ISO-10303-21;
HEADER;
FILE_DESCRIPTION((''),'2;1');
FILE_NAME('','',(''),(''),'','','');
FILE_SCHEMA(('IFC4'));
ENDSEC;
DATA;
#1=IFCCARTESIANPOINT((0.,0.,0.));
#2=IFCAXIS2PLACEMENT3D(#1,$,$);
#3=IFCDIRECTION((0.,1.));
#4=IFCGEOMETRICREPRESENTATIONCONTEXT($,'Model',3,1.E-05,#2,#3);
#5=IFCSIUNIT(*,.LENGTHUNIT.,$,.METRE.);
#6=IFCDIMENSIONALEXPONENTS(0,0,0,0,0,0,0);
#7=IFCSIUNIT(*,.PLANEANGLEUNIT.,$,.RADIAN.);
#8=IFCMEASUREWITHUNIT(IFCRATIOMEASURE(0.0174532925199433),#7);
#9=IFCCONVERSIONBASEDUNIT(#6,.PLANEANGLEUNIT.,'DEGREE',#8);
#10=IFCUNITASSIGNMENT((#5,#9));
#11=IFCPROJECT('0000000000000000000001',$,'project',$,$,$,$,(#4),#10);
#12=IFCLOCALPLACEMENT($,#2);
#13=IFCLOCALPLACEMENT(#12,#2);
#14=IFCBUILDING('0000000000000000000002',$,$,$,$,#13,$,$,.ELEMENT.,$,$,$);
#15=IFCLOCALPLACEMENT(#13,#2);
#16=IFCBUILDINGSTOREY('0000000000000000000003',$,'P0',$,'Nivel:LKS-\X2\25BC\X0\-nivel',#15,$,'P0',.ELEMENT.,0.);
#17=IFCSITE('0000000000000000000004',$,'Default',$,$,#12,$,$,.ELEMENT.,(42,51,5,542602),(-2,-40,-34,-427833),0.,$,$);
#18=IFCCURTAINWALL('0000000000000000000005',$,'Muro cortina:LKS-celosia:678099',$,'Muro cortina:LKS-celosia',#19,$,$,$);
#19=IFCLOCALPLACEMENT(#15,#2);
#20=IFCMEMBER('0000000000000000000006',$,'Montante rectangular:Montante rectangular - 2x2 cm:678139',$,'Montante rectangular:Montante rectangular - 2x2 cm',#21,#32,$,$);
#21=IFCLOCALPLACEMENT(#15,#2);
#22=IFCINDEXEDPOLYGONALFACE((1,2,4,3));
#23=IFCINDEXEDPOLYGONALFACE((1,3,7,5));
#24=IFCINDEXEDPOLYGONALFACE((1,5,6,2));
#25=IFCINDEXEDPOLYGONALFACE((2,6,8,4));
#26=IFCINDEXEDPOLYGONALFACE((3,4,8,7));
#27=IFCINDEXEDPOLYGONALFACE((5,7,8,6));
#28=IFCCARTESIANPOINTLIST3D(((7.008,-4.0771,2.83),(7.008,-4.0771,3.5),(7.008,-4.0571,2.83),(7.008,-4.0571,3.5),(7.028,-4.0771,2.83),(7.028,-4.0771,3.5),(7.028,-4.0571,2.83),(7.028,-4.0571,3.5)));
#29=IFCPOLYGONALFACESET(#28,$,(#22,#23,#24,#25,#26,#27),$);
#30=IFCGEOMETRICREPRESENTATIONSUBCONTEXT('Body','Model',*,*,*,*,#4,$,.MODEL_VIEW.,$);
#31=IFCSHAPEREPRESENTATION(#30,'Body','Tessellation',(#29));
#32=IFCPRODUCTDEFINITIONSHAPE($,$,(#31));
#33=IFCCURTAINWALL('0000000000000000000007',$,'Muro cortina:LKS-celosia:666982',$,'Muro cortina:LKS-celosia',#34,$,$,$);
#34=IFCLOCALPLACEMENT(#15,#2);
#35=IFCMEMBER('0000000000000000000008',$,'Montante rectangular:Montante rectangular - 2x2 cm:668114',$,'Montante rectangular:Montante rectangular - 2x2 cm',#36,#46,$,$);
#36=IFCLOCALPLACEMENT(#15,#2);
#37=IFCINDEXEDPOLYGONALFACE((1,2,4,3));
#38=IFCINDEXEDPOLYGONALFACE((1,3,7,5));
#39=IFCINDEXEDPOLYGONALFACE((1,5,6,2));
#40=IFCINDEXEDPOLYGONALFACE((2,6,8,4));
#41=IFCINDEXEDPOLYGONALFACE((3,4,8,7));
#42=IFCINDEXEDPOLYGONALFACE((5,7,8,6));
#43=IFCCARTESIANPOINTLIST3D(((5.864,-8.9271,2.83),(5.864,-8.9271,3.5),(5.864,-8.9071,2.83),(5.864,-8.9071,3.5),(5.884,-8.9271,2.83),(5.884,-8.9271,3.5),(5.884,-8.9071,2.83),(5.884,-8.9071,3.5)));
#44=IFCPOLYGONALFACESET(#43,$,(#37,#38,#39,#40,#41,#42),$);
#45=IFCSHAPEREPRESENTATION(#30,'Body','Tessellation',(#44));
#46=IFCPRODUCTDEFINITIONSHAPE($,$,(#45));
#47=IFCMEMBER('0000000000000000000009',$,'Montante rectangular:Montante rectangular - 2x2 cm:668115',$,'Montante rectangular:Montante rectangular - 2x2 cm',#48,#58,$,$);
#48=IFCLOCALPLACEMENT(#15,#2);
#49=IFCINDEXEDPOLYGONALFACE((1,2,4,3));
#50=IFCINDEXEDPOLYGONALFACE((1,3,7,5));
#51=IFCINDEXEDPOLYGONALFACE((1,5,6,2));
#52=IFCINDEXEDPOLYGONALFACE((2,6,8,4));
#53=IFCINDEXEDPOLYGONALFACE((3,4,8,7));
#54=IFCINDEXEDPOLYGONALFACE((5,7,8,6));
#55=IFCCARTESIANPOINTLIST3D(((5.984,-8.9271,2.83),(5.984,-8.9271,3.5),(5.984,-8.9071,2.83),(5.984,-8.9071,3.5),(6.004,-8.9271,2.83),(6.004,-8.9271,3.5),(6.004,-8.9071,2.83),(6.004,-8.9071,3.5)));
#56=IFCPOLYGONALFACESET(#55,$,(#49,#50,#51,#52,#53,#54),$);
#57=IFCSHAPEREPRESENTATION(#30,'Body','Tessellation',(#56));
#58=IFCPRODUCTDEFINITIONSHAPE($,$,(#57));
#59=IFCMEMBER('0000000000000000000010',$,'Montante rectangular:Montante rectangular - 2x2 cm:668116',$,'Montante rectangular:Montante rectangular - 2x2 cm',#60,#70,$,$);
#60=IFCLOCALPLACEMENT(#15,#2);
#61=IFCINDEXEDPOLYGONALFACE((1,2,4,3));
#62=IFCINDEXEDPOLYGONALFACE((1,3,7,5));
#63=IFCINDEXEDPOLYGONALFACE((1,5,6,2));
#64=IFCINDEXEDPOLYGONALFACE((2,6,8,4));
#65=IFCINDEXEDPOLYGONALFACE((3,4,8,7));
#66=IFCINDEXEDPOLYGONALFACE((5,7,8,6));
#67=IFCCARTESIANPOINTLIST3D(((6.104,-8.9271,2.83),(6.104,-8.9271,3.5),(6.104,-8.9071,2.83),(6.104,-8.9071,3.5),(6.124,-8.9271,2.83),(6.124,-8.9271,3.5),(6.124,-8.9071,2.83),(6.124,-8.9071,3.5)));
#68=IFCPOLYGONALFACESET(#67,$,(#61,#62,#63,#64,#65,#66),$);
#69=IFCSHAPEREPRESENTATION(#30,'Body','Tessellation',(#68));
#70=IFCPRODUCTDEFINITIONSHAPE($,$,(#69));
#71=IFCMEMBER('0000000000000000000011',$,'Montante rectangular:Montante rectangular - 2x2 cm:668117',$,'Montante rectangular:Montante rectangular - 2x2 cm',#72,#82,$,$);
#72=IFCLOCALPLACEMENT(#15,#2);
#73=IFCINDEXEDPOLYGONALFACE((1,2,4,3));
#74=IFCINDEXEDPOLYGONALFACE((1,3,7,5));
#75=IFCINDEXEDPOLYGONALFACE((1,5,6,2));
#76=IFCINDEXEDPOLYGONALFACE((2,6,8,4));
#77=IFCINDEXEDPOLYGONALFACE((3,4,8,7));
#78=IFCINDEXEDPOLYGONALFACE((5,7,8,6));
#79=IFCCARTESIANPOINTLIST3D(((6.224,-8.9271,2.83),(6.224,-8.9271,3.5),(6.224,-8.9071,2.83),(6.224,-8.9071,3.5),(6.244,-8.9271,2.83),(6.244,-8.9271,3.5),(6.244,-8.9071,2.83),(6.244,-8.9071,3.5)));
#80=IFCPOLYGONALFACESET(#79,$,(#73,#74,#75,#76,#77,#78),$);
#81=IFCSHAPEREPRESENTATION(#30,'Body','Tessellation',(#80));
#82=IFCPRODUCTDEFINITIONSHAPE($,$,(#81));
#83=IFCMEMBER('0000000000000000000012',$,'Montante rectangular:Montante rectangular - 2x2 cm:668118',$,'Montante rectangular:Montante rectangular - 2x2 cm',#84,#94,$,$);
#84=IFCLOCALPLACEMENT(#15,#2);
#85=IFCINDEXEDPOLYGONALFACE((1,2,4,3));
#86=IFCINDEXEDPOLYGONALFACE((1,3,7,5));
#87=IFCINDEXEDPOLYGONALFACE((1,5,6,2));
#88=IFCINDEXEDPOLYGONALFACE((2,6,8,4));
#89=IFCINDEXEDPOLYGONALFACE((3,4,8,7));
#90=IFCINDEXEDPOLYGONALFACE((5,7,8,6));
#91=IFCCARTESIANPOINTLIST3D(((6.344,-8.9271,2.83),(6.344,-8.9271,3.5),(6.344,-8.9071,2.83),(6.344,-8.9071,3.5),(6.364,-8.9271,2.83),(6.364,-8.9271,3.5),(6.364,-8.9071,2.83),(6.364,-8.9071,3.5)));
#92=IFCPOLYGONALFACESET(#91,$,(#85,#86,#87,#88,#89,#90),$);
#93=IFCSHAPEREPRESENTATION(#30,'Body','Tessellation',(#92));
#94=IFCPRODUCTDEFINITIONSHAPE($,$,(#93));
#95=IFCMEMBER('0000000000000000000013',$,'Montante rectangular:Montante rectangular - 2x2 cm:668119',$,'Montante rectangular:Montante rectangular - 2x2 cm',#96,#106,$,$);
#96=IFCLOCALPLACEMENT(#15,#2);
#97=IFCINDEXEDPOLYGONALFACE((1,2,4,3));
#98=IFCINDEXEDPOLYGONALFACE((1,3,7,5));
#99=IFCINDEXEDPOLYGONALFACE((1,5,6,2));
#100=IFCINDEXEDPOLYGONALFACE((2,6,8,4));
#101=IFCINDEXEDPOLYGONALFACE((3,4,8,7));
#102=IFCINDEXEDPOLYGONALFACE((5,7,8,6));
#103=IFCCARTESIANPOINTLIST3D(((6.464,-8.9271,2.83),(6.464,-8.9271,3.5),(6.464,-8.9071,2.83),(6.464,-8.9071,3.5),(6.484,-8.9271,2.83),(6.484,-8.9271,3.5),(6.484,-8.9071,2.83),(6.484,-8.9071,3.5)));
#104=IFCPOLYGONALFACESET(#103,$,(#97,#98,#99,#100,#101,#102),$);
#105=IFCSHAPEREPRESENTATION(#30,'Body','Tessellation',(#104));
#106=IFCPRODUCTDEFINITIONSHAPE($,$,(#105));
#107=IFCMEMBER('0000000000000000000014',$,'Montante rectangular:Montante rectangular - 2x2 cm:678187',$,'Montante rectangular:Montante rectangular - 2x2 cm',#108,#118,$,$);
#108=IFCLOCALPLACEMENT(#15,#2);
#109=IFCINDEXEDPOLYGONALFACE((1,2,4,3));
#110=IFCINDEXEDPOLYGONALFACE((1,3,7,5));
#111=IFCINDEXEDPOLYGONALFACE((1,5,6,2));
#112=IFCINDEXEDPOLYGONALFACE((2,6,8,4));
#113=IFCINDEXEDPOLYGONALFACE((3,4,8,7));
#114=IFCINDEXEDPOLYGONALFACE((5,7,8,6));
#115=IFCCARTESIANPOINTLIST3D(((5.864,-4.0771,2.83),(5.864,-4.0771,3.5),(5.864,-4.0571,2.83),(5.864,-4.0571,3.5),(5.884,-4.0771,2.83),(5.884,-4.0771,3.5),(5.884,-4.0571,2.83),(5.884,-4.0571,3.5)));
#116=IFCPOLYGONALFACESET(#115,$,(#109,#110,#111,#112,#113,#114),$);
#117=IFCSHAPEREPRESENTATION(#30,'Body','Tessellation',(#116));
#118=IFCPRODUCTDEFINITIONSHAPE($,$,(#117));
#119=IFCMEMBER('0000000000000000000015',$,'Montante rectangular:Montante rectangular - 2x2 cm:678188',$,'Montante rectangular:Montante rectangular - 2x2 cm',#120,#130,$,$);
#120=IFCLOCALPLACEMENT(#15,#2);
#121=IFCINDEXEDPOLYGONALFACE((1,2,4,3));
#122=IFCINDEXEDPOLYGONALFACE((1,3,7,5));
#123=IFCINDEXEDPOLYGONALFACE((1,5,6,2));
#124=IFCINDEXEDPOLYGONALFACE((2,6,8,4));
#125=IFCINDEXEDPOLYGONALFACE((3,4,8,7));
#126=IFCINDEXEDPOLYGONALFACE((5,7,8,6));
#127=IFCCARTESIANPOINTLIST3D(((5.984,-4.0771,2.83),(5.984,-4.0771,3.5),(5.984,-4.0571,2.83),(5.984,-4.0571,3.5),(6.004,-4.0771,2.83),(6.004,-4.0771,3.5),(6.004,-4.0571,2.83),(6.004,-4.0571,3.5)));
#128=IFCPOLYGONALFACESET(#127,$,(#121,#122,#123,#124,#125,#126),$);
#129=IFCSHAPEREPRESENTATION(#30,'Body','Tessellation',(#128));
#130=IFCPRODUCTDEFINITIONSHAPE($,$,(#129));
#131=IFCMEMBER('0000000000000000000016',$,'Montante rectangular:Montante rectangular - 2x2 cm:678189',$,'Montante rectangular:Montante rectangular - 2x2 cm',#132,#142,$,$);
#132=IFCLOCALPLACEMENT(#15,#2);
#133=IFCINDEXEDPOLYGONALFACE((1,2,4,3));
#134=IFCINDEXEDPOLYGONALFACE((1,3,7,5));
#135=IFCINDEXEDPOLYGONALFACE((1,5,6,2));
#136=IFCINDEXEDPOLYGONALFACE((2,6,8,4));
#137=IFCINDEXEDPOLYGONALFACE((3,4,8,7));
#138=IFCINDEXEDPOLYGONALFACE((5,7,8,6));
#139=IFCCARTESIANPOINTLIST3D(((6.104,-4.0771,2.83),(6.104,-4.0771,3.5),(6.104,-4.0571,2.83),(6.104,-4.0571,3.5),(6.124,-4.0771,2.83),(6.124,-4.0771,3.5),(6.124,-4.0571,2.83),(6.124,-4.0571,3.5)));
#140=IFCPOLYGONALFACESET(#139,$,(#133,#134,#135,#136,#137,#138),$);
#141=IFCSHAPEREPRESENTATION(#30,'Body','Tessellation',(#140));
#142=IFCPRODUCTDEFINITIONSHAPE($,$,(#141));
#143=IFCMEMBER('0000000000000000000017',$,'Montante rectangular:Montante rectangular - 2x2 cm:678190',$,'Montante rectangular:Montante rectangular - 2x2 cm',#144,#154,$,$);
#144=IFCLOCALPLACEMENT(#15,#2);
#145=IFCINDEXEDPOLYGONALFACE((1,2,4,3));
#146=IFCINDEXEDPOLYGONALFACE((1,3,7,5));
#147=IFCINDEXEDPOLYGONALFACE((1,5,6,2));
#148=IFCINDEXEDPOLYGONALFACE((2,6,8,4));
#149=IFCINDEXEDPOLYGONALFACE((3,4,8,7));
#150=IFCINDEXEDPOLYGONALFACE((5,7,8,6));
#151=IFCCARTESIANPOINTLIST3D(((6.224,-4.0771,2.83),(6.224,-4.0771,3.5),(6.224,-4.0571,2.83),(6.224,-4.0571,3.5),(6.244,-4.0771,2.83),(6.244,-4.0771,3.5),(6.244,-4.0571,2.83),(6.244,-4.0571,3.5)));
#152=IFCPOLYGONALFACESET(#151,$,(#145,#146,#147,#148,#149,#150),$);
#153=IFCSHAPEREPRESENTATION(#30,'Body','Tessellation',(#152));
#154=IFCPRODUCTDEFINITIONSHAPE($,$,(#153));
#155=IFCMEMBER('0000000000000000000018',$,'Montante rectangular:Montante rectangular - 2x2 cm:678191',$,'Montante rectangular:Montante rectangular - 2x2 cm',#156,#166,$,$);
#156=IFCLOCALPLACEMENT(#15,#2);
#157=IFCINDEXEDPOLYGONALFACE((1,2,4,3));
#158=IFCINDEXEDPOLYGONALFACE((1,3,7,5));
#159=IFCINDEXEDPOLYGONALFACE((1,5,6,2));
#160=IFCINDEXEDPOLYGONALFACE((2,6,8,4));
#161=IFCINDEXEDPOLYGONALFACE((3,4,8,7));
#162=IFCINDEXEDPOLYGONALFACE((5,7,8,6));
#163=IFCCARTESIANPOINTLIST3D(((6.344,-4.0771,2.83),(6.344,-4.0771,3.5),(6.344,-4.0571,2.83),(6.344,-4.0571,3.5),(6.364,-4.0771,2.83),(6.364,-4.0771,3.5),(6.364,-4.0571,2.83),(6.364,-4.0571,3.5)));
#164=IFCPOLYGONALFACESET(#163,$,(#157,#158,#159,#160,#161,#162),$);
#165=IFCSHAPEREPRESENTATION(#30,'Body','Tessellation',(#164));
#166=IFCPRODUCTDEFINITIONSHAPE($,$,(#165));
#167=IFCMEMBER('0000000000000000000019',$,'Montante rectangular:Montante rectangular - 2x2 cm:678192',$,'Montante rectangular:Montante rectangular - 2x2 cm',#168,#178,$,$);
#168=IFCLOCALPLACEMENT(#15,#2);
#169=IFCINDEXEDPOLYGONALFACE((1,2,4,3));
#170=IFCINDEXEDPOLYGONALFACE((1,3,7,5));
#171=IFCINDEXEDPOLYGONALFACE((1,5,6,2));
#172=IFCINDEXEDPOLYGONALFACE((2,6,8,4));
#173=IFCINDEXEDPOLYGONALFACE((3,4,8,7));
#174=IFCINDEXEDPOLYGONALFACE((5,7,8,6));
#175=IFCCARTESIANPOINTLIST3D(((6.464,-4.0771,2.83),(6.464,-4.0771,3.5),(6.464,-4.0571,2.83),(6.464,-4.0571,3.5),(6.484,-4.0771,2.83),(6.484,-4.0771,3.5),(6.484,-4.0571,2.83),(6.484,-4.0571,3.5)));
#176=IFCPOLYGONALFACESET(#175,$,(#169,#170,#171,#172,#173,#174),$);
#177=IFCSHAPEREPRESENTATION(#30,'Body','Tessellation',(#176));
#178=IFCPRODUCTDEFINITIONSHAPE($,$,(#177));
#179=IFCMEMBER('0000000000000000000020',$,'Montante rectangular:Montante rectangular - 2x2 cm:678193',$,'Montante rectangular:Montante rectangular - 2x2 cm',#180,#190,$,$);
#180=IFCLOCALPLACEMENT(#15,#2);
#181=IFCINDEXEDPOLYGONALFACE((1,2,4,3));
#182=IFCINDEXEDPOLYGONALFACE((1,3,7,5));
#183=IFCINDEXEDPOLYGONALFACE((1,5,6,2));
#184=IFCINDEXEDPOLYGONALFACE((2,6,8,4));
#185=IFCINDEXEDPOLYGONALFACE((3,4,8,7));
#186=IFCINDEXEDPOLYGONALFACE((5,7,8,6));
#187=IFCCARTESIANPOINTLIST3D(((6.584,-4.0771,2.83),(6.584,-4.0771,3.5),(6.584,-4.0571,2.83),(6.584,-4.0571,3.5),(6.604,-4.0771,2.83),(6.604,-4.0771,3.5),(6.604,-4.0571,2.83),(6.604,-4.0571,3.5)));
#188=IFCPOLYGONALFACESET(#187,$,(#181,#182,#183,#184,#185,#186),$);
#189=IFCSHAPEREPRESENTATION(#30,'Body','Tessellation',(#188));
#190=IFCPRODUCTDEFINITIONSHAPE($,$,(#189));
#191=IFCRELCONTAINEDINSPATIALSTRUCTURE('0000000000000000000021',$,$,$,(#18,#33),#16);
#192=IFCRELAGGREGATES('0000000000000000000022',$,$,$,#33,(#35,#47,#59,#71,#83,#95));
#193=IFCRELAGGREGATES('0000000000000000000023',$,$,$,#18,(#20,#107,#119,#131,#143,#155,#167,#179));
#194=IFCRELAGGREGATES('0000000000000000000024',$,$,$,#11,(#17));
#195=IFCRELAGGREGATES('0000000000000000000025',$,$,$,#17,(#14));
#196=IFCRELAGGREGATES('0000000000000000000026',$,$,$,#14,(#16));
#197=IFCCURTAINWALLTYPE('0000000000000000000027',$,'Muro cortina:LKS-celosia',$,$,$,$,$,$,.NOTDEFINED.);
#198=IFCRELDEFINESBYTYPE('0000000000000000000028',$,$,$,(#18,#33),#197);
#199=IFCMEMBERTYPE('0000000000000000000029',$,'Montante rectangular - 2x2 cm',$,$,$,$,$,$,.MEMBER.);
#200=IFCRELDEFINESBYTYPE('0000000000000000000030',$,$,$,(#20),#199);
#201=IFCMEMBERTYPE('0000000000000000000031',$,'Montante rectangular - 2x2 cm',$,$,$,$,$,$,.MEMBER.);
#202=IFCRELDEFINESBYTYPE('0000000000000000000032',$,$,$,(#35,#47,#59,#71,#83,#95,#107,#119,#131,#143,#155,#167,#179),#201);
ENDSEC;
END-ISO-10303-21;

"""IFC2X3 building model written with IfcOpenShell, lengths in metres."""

from ifc_helpers import new_model, entity, si_unit, converted_unit, direction, frame, origin, origin_2d_with_axis, place, context, subcontext, project, spatial, rectangle, extrude, source, transform, mapped, type_object, type_shapes, element, aggregate, save


model = new_model("IFC2X3")

# Units and contexts
model_context = context("Model", 3, precision=1e-05, world=origin(), true_north=direction((0.0, 1.0)))
body_context = subcontext(model_context, "Body", "Model", "MODEL_VIEW")
ifc_project = project(units=[si_unit("LENGTHUNIT", "METRE"), converted_unit("PLANEANGLEUNIT", "DEGREE", entity("IfcRatioMeasure", 0.0174532925199433), si_unit("PLANEANGLEUNIT", "RADIAN"), dimensions=[0, 0, 0, 0, 0, 0, 0])], contexts=[model_context])

# Site, building, storey
site_placement = place(None, origin())
site = spatial("IfcSite", under=ifc_project, at=site_placement, Name="Default", CompositionType="ELEMENT", RefLatitude=(42, 51, 5, 542602), RefLongitude=(-2, -40, -34, -427833), RefElevation=0.0)
building_placement = place(site_placement, origin())
building = spatial("IfcBuilding", under=site, at=building_placement, CompositionType="ELEMENT")
storey_placement = place(building_placement, origin())
storey = spatial("IfcBuildingStorey", under=building, at=storey_placement, Name="P0", ObjectType="Nivel:LKS-▼-nivel", LongName="P0", CompositionType="ELEMENT", Elevation=0.0)

# Curtain wall, member
curtain_wall_type = type_object("IfcCurtainWallType", Name="Muro cortina:LKS-celosia", PredefinedType="NOTDEFINED")
curtain_wall_1_placement = place(storey_placement, origin())
curtain_wall_1 = element("IfcCurtainWall", 1, at=curtain_wall_1_placement, inside=storey, type_object=curtain_wall_type, Name="Muro cortina:LKS-celosia:678099", ObjectType="Muro cortina:LKS-celosia")
member_type_1 = type_object("IfcMemberType", Name="Montante rectangular - 2x2 cm", PredefinedType="MEMBER")
shared_shape_1 = source(origin(), body_context, "Body", "SweptSolid", [
    extrude(rectangle(XDim=0.02, YDim=0.02, at=origin_2d_with_axis()), frame((-0.01, -0.1, -0.67), z_axis=(0.0, 0.0, 1.0), x_axis=(0.0, -1.0, 0.0)), (0.0, 0.0, 1.0), 0.67),
])
type_shapes(member_type_1, [shared_shape_1])
member_1_placement = place(storey_placement, frame((7.028, -4.1671, 2.83), z_axis=(0.0, 0.0, -1.0), x_axis=(1.0, 0.0, 0.0)))
member_1 = element("IfcMember", 2, at=member_1_placement, type_object=member_type_1, Name="Montante rectangular:Montante rectangular - 2x2 cm:678139", ObjectType="Montante rectangular:Montante rectangular - 2x2 cm", context=body_context, shape_type="MappedRepresentation", body=[
    mapped(shared_shape_1, transform((0.0, 0.0, 0.0), scale=1.0)),
])

# Curtain wall, members
curtain_wall_2_placement = place(storey_placement, origin())
curtain_wall_2 = element("IfcCurtainWall", 3, at=curtain_wall_2_placement, inside=storey, type_object=curtain_wall_type, Name="Muro cortina:LKS-celosia:666982", ObjectType="Muro cortina:LKS-celosia")
member_type_2 = type_object("IfcMemberType", Name="Montante rectangular - 2x2 cm", PredefinedType="MEMBER")
shared_shape_2 = source(origin(), body_context, "Body", "SweptSolid", [
    extrude(rectangle(XDim=0.02, YDim=0.02, at=origin_2d_with_axis()), frame((0.0, -0.1, -0.67), z_axis=(0.0, 0.0, 1.0), x_axis=(0.0, -1.0, 0.0)), (0.0, 0.0, 1.0), 0.67),
])
type_shapes(member_type_2, [shared_shape_2])
member_2_placement = place(storey_placement, frame((5.874, -9.0171, 2.83), z_axis=(0.0, 0.0, -1.0), x_axis=(1.0, 0.0, 0.0)))
member_2 = element("IfcMember", 4, at=member_2_placement, type_object=member_type_2, Name="Montante rectangular:Montante rectangular - 2x2 cm:668114", ObjectType="Montante rectangular:Montante rectangular - 2x2 cm", context=body_context, shape_type="MappedRepresentation", body=[
    mapped(shared_shape_2, transform((0.0, 0.0, 0.0), scale=1.0)),
])
member_3_placement = place(storey_placement, frame((5.994, -9.0171, 2.83), z_axis=(0.0, 0.0, -1.0), x_axis=(1.0, 0.0, 0.0)))
member_3 = element("IfcMember", 5, at=member_3_placement, type_object=member_type_2, Name="Montante rectangular:Montante rectangular - 2x2 cm:668115", ObjectType="Montante rectangular:Montante rectangular - 2x2 cm", context=body_context, shape_type="MappedRepresentation", body=[
    mapped(shared_shape_2, transform((0.0, 0.0, 0.0), scale=1.0)),
])
member_4_placement = place(storey_placement, frame((6.114, -9.0171, 2.83), z_axis=(0.0, 0.0, -1.0), x_axis=(1.0, 0.0, 0.0)))
member_4 = element("IfcMember", 6, at=member_4_placement, type_object=member_type_2, Name="Montante rectangular:Montante rectangular - 2x2 cm:668116", ObjectType="Montante rectangular:Montante rectangular - 2x2 cm", context=body_context, shape_type="MappedRepresentation", body=[
    mapped(shared_shape_2, transform((0.0, 0.0, 0.0), scale=1.0)),
])
member_5_placement = place(storey_placement, frame((6.234, -9.0171, 2.83), z_axis=(0.0, 0.0, -1.0), x_axis=(1.0, 0.0, 0.0)))
member_5 = element("IfcMember", 7, at=member_5_placement, type_object=member_type_2, Name="Montante rectangular:Montante rectangular - 2x2 cm:668117", ObjectType="Montante rectangular:Montante rectangular - 2x2 cm", context=body_context, shape_type="MappedRepresentation", body=[
    mapped(shared_shape_2, transform((0.0, 0.0, 0.0), scale=1.0)),
])
member_6_placement = place(storey_placement, frame((6.354, -9.0171, 2.83), z_axis=(0.0, 0.0, -1.0), x_axis=(1.0, 0.0, 0.0)))
member_6 = element("IfcMember", 8, at=member_6_placement, type_object=member_type_2, Name="Montante rectangular:Montante rectangular - 2x2 cm:668118", ObjectType="Montante rectangular:Montante rectangular - 2x2 cm", context=body_context, shape_type="MappedRepresentation", body=[
    mapped(shared_shape_2, transform((0.0, 0.0, 0.0), scale=1.0)),
])
member_7_placement = place(storey_placement, frame((6.474, -9.0171, 2.83), z_axis=(0.0, 0.0, -1.0), x_axis=(1.0, 0.0, 0.0)))
member_7 = element("IfcMember", 9, at=member_7_placement, type_object=member_type_2, Name="Montante rectangular:Montante rectangular - 2x2 cm:668119", ObjectType="Montante rectangular:Montante rectangular - 2x2 cm", context=body_context, shape_type="MappedRepresentation", body=[
    mapped(shared_shape_2, transform((0.0, 0.0, 0.0), scale=1.0)),
])
aggregate(curtain_wall_2, [member_2, member_3, member_4, member_5, member_6, member_7])

# Members
member_8_placement = place(storey_placement, frame((5.874, -4.1671, 2.83), z_axis=(0.0, 0.0, -1.0), x_axis=(1.0, 0.0, 0.0)))
member_8 = element("IfcMember", 10, at=member_8_placement, type_object=member_type_2, Name="Montante rectangular:Montante rectangular - 2x2 cm:678187", ObjectType="Montante rectangular:Montante rectangular - 2x2 cm", context=body_context, shape_type="MappedRepresentation", body=[
    mapped(shared_shape_2, transform((0.0, 0.0, 0.0), scale=1.0)),
])
member_9_placement = place(storey_placement, frame((5.994, -4.1671, 2.83), z_axis=(0.0, 0.0, -1.0), x_axis=(1.0, 0.0, 0.0)))
member_9 = element("IfcMember", 11, at=member_9_placement, type_object=member_type_2, Name="Montante rectangular:Montante rectangular - 2x2 cm:678188", ObjectType="Montante rectangular:Montante rectangular - 2x2 cm", context=body_context, shape_type="MappedRepresentation", body=[
    mapped(shared_shape_2, transform((0.0, 0.0, 0.0), scale=1.0)),
])
member_10_placement = place(storey_placement, frame((6.114, -4.1671, 2.83), z_axis=(0.0, 0.0, -1.0), x_axis=(1.0, 0.0, 0.0)))
member_10 = element("IfcMember", 12, at=member_10_placement, type_object=member_type_2, Name="Montante rectangular:Montante rectangular - 2x2 cm:678189", ObjectType="Montante rectangular:Montante rectangular - 2x2 cm", context=body_context, shape_type="MappedRepresentation", body=[
    mapped(shared_shape_2, transform((0.0, 0.0, 0.0), scale=1.0)),
])
member_11_placement = place(storey_placement, frame((6.234, -4.1671, 2.83), z_axis=(0.0, 0.0, -1.0), x_axis=(1.0, 0.0, 0.0)))
member_11 = element("IfcMember", 13, at=member_11_placement, type_object=member_type_2, Name="Montante rectangular:Montante rectangular - 2x2 cm:678190", ObjectType="Montante rectangular:Montante rectangular - 2x2 cm", context=body_context, shape_type="MappedRepresentation", body=[
    mapped(shared_shape_2, transform((0.0, 0.0, 0.0), scale=1.0)),
])
member_12_placement = place(storey_placement, frame((6.354, -4.1671, 2.83), z_axis=(0.0, 0.0, -1.0), x_axis=(1.0, 0.0, 0.0)))
member_12 = element("IfcMember", 14, at=member_12_placement, type_object=member_type_2, Name="Montante rectangular:Montante rectangular - 2x2 cm:678191", ObjectType="Montante rectangular:Montante rectangular - 2x2 cm", context=body_context, shape_type="MappedRepresentation", body=[
    mapped(shared_shape_2, transform((0.0, 0.0, 0.0), scale=1.0)),
])
member_13_placement = place(storey_placement, frame((6.474, -4.1671, 2.83), z_axis=(0.0, 0.0, -1.0), x_axis=(1.0, 0.0, 0.0)))
member_13 = element("IfcMember", 15, at=member_13_placement, type_object=member_type_2, Name="Montante rectangular:Montante rectangular - 2x2 cm:678192", ObjectType="Montante rectangular:Montante rectangular - 2x2 cm", context=body_context, shape_type="MappedRepresentation", body=[
    mapped(shared_shape_2, transform((0.0, 0.0, 0.0), scale=1.0)),
])
member_14_placement = place(storey_placement, frame((6.594, -4.1671, 2.83), z_axis=(0.0, 0.0, -1.0), x_axis=(1.0, 0.0, 0.0)))
member_14 = element("IfcMember", 16, at=member_14_placement, type_object=member_type_2, Name="Montante rectangular:Montante rectangular - 2x2 cm:678193", ObjectType="Montante rectangular:Montante rectangular - 2x2 cm", context=body_context, shape_type="MappedRepresentation", body=[
    mapped(shared_shape_2, transform((0.0, 0.0, 0.0), scale=1.0)),
])

aggregate(curtain_wall_1, [member_1, member_8, member_9, member_10, member_11, member_12, member_13, member_14])

save(model, "model.ifc")
